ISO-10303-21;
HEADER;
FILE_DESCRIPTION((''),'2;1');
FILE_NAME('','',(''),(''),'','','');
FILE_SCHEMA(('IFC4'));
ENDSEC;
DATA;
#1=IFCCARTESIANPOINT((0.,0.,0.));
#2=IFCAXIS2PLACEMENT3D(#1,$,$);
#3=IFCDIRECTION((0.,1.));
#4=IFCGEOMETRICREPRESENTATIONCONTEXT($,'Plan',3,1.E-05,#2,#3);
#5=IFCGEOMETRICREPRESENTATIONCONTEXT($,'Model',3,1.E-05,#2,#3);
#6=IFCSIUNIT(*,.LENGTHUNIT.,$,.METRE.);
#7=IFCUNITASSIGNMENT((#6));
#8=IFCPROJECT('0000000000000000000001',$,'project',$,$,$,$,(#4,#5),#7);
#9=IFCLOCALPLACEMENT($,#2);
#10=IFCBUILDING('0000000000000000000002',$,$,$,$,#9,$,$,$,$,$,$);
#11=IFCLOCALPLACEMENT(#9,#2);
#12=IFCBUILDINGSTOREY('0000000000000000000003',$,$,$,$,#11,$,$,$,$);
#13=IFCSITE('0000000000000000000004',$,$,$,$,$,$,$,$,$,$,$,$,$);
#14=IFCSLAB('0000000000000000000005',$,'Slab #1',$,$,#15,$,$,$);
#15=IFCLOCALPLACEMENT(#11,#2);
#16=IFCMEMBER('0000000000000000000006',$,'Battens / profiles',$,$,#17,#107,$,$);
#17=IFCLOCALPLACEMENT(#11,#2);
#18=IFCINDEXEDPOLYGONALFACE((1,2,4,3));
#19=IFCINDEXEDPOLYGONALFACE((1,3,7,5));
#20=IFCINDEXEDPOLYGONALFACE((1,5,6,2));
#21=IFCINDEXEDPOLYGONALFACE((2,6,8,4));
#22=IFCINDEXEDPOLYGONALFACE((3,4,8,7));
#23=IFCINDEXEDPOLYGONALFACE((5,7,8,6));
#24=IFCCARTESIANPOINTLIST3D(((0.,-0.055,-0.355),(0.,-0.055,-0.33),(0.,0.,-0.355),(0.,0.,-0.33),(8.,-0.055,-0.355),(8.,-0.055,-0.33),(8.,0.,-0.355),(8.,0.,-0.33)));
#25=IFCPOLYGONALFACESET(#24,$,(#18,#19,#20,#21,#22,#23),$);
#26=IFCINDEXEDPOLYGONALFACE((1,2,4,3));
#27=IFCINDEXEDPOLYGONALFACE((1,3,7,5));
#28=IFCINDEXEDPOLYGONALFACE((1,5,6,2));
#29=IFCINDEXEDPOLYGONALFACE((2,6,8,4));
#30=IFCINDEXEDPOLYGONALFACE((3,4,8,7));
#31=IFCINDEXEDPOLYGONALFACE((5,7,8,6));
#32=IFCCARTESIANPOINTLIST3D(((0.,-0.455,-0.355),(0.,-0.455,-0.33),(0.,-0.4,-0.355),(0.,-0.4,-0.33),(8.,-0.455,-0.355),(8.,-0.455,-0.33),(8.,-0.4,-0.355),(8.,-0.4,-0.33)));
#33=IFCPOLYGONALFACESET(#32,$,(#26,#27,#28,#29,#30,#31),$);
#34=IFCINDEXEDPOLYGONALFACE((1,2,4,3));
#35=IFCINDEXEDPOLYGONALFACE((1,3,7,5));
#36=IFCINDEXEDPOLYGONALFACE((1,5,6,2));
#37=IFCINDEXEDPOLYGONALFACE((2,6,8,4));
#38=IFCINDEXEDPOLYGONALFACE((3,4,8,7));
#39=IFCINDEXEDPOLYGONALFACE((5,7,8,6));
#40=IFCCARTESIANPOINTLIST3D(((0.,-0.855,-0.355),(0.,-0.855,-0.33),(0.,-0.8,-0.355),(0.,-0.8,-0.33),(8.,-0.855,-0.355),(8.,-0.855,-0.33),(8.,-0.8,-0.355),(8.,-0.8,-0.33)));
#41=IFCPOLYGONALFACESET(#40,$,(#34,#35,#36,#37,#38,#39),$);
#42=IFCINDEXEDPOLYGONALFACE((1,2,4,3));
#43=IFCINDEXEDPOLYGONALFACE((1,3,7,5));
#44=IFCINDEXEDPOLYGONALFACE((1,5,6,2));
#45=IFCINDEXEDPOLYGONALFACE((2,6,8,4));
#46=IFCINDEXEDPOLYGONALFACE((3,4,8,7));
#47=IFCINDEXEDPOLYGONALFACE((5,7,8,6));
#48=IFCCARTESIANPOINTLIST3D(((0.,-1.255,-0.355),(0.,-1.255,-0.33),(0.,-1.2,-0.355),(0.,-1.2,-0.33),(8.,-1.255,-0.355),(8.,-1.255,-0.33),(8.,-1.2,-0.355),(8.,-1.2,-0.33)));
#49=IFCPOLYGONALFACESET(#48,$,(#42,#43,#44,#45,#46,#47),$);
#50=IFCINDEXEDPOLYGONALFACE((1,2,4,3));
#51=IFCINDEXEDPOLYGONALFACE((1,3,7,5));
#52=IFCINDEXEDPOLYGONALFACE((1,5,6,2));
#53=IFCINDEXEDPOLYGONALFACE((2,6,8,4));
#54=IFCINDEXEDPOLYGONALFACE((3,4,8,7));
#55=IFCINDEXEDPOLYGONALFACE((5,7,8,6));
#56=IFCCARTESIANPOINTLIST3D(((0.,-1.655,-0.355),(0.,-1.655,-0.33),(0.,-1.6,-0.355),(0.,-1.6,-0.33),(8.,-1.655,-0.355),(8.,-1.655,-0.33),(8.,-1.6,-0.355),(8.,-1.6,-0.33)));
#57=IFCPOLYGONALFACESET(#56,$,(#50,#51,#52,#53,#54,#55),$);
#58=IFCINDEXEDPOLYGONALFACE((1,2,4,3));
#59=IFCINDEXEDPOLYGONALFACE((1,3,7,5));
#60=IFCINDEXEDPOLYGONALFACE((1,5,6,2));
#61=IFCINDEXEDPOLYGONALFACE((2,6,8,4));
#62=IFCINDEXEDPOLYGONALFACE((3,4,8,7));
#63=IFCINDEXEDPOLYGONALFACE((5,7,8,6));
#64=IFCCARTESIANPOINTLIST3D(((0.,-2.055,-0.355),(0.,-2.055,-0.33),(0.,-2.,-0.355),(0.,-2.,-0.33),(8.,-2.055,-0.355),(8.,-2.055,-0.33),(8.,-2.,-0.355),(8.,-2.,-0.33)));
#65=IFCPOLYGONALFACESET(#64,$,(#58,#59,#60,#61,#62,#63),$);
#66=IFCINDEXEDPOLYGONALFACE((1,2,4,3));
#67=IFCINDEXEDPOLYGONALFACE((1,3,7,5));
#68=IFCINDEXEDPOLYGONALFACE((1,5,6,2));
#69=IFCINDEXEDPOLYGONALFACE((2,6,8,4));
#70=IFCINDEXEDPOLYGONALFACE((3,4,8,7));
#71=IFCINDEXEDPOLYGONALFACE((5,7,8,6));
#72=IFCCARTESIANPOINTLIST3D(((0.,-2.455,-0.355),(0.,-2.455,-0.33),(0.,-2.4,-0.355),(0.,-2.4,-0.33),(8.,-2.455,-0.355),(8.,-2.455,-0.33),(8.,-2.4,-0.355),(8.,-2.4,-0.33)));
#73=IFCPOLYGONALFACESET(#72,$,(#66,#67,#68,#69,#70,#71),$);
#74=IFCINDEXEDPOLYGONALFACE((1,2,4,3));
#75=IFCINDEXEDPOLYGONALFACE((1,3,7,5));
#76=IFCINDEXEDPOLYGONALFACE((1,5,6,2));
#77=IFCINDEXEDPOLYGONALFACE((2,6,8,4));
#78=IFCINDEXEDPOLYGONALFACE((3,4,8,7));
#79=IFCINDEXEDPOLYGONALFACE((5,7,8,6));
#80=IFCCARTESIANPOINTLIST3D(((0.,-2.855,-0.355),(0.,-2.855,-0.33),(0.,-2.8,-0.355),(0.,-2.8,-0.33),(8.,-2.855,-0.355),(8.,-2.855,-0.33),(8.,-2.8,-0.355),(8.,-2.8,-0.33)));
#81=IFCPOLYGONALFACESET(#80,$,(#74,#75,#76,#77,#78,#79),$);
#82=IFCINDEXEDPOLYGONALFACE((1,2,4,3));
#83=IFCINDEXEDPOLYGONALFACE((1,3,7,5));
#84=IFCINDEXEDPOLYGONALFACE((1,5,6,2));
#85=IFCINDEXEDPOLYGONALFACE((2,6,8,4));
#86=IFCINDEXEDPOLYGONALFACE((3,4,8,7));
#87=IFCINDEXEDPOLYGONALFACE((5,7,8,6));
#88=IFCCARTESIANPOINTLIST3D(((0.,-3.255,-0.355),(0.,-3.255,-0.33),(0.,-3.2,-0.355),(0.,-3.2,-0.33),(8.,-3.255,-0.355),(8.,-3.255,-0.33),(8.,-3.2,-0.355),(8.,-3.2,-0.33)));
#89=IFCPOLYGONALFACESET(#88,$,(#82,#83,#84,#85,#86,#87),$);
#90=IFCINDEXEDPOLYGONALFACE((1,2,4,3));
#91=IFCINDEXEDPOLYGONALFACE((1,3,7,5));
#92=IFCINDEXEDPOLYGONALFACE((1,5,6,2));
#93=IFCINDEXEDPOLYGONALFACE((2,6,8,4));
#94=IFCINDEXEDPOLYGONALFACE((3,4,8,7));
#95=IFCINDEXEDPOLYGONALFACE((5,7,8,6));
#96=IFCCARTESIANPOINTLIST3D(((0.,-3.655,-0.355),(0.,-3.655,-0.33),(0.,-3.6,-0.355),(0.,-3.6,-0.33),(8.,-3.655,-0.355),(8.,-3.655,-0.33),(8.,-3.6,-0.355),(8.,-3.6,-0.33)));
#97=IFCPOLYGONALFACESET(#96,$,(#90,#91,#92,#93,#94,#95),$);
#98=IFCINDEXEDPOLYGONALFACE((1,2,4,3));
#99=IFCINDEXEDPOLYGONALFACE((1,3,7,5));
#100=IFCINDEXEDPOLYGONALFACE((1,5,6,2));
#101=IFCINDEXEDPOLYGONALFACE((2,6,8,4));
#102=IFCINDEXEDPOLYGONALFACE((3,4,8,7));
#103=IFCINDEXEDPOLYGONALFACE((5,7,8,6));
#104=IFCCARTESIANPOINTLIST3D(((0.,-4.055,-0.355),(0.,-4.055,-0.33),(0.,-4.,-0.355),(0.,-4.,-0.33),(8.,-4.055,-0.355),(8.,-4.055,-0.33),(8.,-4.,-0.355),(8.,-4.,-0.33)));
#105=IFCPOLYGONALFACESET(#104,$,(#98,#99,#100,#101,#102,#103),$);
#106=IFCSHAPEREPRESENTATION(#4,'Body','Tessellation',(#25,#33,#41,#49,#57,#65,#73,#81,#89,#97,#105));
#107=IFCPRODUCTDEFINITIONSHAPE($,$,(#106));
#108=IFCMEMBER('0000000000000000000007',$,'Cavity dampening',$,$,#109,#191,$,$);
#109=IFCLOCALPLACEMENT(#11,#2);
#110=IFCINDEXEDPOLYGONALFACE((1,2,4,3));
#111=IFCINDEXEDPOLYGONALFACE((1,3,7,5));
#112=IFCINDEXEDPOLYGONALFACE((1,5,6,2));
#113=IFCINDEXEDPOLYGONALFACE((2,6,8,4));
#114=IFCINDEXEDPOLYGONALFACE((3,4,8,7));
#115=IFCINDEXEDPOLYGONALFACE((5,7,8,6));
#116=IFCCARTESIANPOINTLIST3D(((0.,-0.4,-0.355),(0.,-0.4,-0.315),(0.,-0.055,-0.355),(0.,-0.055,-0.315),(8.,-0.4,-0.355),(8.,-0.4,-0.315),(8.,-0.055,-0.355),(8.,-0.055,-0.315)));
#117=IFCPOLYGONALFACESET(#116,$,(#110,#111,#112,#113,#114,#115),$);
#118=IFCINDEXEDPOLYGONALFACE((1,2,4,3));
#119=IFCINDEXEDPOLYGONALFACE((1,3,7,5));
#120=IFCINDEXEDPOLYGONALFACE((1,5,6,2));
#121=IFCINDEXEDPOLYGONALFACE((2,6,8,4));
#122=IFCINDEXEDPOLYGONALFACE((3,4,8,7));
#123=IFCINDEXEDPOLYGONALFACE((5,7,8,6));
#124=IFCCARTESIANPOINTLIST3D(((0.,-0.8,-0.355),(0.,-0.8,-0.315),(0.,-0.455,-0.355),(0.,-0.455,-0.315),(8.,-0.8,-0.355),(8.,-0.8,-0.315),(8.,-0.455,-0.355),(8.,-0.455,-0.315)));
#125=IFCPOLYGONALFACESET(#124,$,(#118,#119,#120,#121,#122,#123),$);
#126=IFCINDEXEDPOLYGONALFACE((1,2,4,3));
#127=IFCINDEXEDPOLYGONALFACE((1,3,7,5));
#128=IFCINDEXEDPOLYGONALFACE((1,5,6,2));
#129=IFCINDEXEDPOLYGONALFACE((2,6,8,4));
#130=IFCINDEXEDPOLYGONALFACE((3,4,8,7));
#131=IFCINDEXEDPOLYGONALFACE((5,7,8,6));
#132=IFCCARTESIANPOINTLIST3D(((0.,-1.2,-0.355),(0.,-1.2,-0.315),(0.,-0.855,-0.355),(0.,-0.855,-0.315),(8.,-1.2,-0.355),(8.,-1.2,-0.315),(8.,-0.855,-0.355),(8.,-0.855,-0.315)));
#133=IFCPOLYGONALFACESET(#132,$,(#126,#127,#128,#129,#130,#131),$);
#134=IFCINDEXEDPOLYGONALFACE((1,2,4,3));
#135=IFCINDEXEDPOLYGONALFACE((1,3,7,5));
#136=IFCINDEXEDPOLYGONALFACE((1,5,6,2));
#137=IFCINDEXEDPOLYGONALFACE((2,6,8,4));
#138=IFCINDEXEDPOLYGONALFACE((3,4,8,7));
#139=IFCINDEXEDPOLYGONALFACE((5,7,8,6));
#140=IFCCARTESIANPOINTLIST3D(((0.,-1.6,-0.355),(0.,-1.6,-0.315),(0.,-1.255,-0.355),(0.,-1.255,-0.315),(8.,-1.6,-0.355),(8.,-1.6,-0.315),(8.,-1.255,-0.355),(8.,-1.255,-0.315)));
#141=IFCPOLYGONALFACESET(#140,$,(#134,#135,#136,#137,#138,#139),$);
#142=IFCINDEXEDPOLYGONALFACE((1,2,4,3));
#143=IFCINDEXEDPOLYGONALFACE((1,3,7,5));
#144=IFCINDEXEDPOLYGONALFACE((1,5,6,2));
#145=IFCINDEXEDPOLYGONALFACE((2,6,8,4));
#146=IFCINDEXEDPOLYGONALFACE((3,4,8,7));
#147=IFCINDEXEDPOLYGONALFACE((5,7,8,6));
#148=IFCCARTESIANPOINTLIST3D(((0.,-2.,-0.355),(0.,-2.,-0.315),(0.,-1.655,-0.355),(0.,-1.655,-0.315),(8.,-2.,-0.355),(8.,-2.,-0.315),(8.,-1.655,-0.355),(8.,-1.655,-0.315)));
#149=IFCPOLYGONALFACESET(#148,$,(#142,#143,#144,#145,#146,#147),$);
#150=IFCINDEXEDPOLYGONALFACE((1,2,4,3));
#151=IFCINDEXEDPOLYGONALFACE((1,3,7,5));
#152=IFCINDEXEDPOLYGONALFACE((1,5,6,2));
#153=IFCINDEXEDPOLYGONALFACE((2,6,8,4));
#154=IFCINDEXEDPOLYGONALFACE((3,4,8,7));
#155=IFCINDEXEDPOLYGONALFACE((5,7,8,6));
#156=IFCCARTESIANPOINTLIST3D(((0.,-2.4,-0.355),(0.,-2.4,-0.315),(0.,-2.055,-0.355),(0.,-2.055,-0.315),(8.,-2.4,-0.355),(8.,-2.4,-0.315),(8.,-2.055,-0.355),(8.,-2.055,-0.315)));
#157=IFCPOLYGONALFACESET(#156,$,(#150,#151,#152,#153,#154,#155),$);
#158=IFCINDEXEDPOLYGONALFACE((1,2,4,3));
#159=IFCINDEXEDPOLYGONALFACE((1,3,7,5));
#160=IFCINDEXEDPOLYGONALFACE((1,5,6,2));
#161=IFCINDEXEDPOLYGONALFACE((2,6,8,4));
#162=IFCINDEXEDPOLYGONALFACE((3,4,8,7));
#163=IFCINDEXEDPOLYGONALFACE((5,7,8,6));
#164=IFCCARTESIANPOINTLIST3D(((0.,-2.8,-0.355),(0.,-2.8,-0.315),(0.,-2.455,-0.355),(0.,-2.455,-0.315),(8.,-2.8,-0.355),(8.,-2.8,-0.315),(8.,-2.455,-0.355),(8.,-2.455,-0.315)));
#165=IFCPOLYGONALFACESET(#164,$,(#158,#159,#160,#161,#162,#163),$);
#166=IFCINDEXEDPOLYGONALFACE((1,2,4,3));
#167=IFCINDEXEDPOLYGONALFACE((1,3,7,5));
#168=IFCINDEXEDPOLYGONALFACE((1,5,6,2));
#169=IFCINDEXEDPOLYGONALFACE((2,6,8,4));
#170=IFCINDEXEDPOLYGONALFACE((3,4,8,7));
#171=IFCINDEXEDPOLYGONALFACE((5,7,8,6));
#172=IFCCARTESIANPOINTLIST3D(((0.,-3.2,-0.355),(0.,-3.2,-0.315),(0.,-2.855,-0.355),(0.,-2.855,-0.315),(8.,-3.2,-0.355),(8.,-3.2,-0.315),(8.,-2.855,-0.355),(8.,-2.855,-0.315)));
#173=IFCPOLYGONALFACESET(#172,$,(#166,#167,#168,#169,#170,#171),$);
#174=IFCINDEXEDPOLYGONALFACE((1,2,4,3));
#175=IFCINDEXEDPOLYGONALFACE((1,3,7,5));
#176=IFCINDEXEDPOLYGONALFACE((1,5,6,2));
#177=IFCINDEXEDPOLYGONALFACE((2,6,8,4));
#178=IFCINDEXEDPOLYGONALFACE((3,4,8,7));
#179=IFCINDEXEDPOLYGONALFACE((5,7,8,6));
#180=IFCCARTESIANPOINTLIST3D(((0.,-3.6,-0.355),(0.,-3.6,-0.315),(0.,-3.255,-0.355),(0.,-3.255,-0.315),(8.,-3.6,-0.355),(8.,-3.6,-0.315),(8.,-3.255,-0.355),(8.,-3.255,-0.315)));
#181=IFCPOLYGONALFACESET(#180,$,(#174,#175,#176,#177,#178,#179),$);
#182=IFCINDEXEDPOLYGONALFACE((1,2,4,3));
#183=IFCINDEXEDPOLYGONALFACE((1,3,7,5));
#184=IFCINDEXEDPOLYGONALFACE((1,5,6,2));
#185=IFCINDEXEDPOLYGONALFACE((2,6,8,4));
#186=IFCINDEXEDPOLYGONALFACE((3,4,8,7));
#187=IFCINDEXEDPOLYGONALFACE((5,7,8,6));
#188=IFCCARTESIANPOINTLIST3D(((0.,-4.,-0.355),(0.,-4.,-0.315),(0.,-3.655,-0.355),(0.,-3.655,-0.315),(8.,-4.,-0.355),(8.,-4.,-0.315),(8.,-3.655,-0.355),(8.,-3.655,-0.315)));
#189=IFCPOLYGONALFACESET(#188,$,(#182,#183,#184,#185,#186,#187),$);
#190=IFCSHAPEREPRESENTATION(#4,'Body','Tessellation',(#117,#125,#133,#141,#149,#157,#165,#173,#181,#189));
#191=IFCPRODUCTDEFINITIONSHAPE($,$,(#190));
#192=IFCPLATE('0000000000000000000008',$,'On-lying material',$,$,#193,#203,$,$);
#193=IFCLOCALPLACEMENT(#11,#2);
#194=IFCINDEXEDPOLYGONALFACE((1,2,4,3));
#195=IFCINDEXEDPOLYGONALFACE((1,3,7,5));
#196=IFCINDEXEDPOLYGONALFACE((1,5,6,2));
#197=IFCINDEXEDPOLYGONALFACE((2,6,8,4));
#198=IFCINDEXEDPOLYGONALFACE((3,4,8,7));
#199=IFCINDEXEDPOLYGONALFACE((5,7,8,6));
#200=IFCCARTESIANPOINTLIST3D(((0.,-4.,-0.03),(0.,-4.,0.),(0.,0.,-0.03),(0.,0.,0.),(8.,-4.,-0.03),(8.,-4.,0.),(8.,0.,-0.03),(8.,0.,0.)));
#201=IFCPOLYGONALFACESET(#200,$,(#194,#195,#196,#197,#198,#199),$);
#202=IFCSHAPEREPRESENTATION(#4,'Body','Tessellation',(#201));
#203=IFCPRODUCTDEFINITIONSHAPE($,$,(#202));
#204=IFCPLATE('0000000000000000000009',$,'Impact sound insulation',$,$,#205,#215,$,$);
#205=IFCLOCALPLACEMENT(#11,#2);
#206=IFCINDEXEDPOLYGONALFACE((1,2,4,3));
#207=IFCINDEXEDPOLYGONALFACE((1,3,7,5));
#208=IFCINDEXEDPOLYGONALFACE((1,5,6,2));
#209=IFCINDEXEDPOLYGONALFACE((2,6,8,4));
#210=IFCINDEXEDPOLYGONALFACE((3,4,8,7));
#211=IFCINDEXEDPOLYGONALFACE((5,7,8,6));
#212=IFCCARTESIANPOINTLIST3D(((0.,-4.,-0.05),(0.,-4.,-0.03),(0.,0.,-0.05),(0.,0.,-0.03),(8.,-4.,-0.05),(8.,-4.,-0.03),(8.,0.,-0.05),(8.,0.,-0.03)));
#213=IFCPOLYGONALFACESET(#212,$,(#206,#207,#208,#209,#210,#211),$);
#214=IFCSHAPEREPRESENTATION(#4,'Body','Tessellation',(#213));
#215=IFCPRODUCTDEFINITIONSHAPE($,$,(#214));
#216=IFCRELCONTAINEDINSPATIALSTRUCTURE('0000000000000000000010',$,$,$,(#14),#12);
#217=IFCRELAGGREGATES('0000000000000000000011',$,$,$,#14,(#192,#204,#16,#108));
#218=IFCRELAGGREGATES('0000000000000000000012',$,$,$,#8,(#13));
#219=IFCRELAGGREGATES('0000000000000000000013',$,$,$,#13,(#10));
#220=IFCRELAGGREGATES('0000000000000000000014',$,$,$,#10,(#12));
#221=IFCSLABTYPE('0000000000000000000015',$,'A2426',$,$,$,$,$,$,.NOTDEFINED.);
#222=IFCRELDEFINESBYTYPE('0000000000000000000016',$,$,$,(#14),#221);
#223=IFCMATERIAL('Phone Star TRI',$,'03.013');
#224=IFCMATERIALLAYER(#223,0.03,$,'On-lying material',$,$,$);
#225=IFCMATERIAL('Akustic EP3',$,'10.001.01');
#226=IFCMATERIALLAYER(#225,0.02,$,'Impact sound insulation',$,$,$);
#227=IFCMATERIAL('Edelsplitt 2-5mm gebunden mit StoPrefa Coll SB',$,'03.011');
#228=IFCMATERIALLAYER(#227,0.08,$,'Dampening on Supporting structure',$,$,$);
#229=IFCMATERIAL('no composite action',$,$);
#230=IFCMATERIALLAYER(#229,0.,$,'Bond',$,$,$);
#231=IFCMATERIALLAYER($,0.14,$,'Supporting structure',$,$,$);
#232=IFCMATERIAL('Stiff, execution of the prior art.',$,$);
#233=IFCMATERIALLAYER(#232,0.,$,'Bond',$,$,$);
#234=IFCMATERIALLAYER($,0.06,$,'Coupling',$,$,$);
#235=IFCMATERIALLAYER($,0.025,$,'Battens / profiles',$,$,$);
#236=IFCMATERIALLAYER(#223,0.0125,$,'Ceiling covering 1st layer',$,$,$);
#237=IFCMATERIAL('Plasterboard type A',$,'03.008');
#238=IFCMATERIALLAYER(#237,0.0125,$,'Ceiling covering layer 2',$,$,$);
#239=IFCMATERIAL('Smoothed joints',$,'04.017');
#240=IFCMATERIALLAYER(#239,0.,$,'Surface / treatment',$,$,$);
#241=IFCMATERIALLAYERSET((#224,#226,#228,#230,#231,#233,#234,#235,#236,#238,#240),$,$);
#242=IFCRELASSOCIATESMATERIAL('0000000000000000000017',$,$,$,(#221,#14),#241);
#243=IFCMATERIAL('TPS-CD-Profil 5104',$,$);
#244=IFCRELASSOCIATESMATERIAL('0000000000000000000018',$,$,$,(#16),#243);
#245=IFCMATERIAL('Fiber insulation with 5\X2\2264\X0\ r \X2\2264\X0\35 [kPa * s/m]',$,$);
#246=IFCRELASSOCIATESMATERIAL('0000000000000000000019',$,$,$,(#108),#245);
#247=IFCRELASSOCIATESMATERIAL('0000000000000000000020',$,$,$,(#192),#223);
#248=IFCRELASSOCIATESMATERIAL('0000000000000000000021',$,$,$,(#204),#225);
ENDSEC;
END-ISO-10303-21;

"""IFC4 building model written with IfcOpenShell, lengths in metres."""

from ifc_helpers import new_model, si_unit, direction, frame, frame_2d, origin, origin_with_axes, place, context, project, spatial, rectangle, extrude, material, layer, layer_set, type_object, element, aggregate, save


model = new_model("IFC4")

# Units and contexts
plan_context = context("Plan", 3, precision=1e-05, world=origin(), true_north=direction((0.0, 1.0)))
model_context = context("Model", 3, precision=1e-05, world=origin(), true_north=direction((0.0, 1.0)))
ifc_project = project(units=[si_unit("LENGTHUNIT", "METRE")], contexts=[plan_context, model_context])

# Site, building, storey
site = spatial("IfcSite", under=ifc_project)
building_placement = place(None, origin())
building = spatial("IfcBuilding", under=site, at=building_placement)
storey_placement = place(building_placement, origin())
storey = spatial("IfcBuildingStorey", under=building, at=storey_placement)

# Slab, members, plates
ifc_material_1 = material(Name="Phone Star TRI", Category="03.013")
ifc_layer_1 = layer(ifc_material_1, 0.03, Name="On-lying material")
ifc_material_2 = material(Name="Akustic EP3", Category="10.001.01")
ifc_layer_2 = layer(ifc_material_2, 0.02, Name="Impact sound insulation")
ifc_material_3 = material(Name="Edelsplitt 2-5mm gebunden mit StoPrefa Coll SB", Category="03.011")
ifc_layer_3 = layer(ifc_material_3, 0.08, Name="Dampening on Supporting structure")
ifc_material_4 = material(Name="no composite action")
ifc_layer_4 = layer(ifc_material_4, 0.0, Name="Bond")
ifc_layer_5 = layer(None, 0.14, Name="Supporting structure")
ifc_material_5 = material(Name="Stiff, execution of the prior art.")
ifc_layer_6 = layer(ifc_material_5, 0.0, Name="Bond")
ifc_layer_7 = layer(None, 0.06, Name="Coupling")
ifc_layer_8 = layer(None, 0.025, Name="Battens / profiles")
ifc_layer_9 = layer(ifc_material_1, 0.0125, Name="Ceiling covering 1st layer")
ifc_material_6 = material(Name="Plasterboard type A", Category="03.008")
ifc_layer_10 = layer(ifc_material_6, 0.0125, Name="Ceiling covering layer 2")
ifc_material_7 = material(Name="Smoothed joints", Category="04.017")
ifc_layer_11 = layer(ifc_material_7, 0.0, Name="Surface / treatment")
ifc_layer_set = layer_set([ifc_layer_1, ifc_layer_2, ifc_layer_3, ifc_layer_4, ifc_layer_5, ifc_layer_6, ifc_layer_7, ifc_layer_8, ifc_layer_9, ifc_layer_10, ifc_layer_11])
slab_type = type_object("IfcSlabType", Name="A2426", PredefinedType="NOTDEFINED", material=ifc_layer_set)
slab_placement = place(None, frame((0.0, 0.0, 0.0), z_axis=(0.0, 0.0, -1.0), x_axis=(1.0, 0.0, 0.0)))
slab = element("IfcSlab", 1, at=slab_placement, inside=storey, type_object=slab_type, material=ifc_layer_set, Name="Slab #1")
ifc_material_8 = material(Name="TPS-CD-Profil 5104")
member_1_placement = place(slab_placement, origin())
member_1 = element("IfcMember", 2, at=member_1_placement, material=ifc_material_8, Name="Battens / profiles", context=plan_context, shape_type="SweptSolid", body=[
    extrude(rectangle(XDim=0.055, YDim=0.025, at=frame_2d((0.0275, 0.0125), x_axis=(1.0, 0.0))), frame((0.0, 0.0, 0.33), z_axis=(1.0, 0.0, 0.0), x_axis=(0.0, 1.0, 0.0)), (0.0, 0.0, 1.0), 8.0),
    extrude(rectangle(XDim=0.055, YDim=0.025, at=frame_2d((0.0275, 0.0125), x_axis=(1.0, 0.0))), frame((0.0, 0.4, 0.33), z_axis=(1.0, 0.0, 0.0), x_axis=(0.0, 1.0, 0.0)), (0.0, 0.0, 1.0), 8.0),
    extrude(rectangle(XDim=0.055, YDim=0.025, at=frame_2d((0.0275, 0.0125), x_axis=(1.0, 0.0))), frame((0.0, 0.8, 0.33), z_axis=(1.0, 0.0, 0.0), x_axis=(0.0, 1.0, 0.0)), (0.0, 0.0, 1.0), 8.0),
    extrude(rectangle(XDim=0.055, YDim=0.025, at=frame_2d((0.0275, 0.0125), x_axis=(1.0, 0.0))), frame((0.0, 1.2, 0.33), z_axis=(1.0, 0.0, 0.0), x_axis=(0.0, 1.0, 0.0)), (0.0, 0.0, 1.0), 8.0),
    extrude(rectangle(XDim=0.055, YDim=0.025, at=frame_2d((0.0275, 0.0125), x_axis=(1.0, 0.0))), frame((0.0, 1.6, 0.33), z_axis=(1.0, 0.0, 0.0), x_axis=(0.0, 1.0, 0.0)), (0.0, 0.0, 1.0), 8.0),
    extrude(rectangle(XDim=0.055, YDim=0.025, at=frame_2d((0.0275, 0.0125), x_axis=(1.0, 0.0))), frame((0.0, 2.0, 0.33), z_axis=(1.0, 0.0, 0.0), x_axis=(0.0, 1.0, 0.0)), (0.0, 0.0, 1.0), 8.0),
    extrude(rectangle(XDim=0.055, YDim=0.025, at=frame_2d((0.0275, 0.0125), x_axis=(1.0, 0.0))), frame((0.0, 2.4, 0.33), z_axis=(1.0, 0.0, 0.0), x_axis=(0.0, 1.0, 0.0)), (0.0, 0.0, 1.0), 8.0),
    extrude(rectangle(XDim=0.055, YDim=0.025, at=frame_2d((0.0275, 0.0125), x_axis=(1.0, 0.0))), frame((0.0, 2.8, 0.33), z_axis=(1.0, 0.0, 0.0), x_axis=(0.0, 1.0, 0.0)), (0.0, 0.0, 1.0), 8.0),
    extrude(rectangle(XDim=0.055, YDim=0.025, at=frame_2d((0.0275, 0.0125), x_axis=(1.0, 0.0))), frame((0.0, 3.2, 0.33), z_axis=(1.0, 0.0, 0.0), x_axis=(0.0, 1.0, 0.0)), (0.0, 0.0, 1.0), 8.0),
    extrude(rectangle(XDim=0.055, YDim=0.025, at=frame_2d((0.0275, 0.0125), x_axis=(1.0, 0.0))), frame((0.0, 3.6, 0.33), z_axis=(1.0, 0.0, 0.0), x_axis=(0.0, 1.0, 0.0)), (0.0, 0.0, 1.0), 8.0),
    extrude(rectangle(XDim=0.055, YDim=0.025, at=frame_2d((0.0275, 0.0125), x_axis=(1.0, 0.0))), frame((0.0, 4.0, 0.33), z_axis=(1.0, 0.0, 0.0), x_axis=(0.0, 1.0, 0.0)), (0.0, 0.0, 1.0), 8.0),
])
ifc_material_9 = material(Name="Fiber insulation with 5≤ r ≤35 [kPa * s/m]")
member_2_placement = place(slab_placement, origin())
member_2 = element("IfcMember", 3, at=member_2_placement, material=ifc_material_9, Name="Cavity dampening", context=plan_context, shape_type="SweptSolid", body=[
    extrude(rectangle(XDim=0.345, YDim=0.04, at=frame_2d((0.1725, 0.02), x_axis=(1.0, 0.0))), frame((0.0, 0.055, 0.315), z_axis=(1.0, 0.0, 0.0), x_axis=(0.0, 1.0, 0.0)), (0.0, 0.0, 1.0), 8.0),
    extrude(rectangle(XDim=0.345, YDim=0.04, at=frame_2d((0.1725, 0.02), x_axis=(1.0, 0.0))), frame((0.0, 0.455, 0.315), z_axis=(1.0, 0.0, 0.0), x_axis=(0.0, 1.0, 0.0)), (0.0, 0.0, 1.0), 8.0),
    extrude(rectangle(XDim=0.345, YDim=0.04, at=frame_2d((0.1725, 0.02), x_axis=(1.0, 0.0))), frame((0.0, 0.855, 0.315), z_axis=(1.0, 0.0, 0.0), x_axis=(0.0, 1.0, 0.0)), (0.0, 0.0, 1.0), 8.0),
    extrude(rectangle(XDim=0.345, YDim=0.04, at=frame_2d((0.1725, 0.02), x_axis=(1.0, 0.0))), frame((0.0, 1.255, 0.315), z_axis=(1.0, 0.0, 0.0), x_axis=(0.0, 1.0, 0.0)), (0.0, 0.0, 1.0), 8.0),
    extrude(rectangle(XDim=0.345, YDim=0.04, at=frame_2d((0.1725, 0.02), x_axis=(1.0, 0.0))), frame((0.0, 1.655, 0.315), z_axis=(1.0, 0.0, 0.0), x_axis=(0.0, 1.0, 0.0)), (0.0, 0.0, 1.0), 8.0),
    extrude(rectangle(XDim=0.345, YDim=0.04, at=frame_2d((0.1725, 0.02), x_axis=(1.0, 0.0))), frame((0.0, 2.055, 0.315), z_axis=(1.0, 0.0, 0.0), x_axis=(0.0, 1.0, 0.0)), (0.0, 0.0, 1.0), 8.0),
    extrude(rectangle(XDim=0.345, YDim=0.04, at=frame_2d((0.1725, 0.02), x_axis=(1.0, 0.0))), frame((0.0, 2.455, 0.315), z_axis=(1.0, 0.0, 0.0), x_axis=(0.0, 1.0, 0.0)), (0.0, 0.0, 1.0), 8.0),
    extrude(rectangle(XDim=0.345, YDim=0.04, at=frame_2d((0.1725, 0.02), x_axis=(1.0, 0.0))), frame((0.0, 2.855, 0.315), z_axis=(1.0, 0.0, 0.0), x_axis=(0.0, 1.0, 0.0)), (0.0, 0.0, 1.0), 8.0),
    extrude(rectangle(XDim=0.345, YDim=0.04, at=frame_2d((0.1725, 0.02), x_axis=(1.0, 0.0))), frame((0.0, 3.255, 0.315), z_axis=(1.0, 0.0, 0.0), x_axis=(0.0, 1.0, 0.0)), (0.0, 0.0, 1.0), 8.0),
    extrude(rectangle(XDim=0.345, YDim=0.04, at=frame_2d((0.1725, 0.02), x_axis=(1.0, 0.0))), frame((0.0, 3.655, 0.315), z_axis=(1.0, 0.0, 0.0), x_axis=(0.0, 1.0, 0.0)), (0.0, 0.0, 1.0), 8.0),
])
plate_1_placement = place(slab_placement, origin())
plate_1 = element("IfcPlate", 4, at=plate_1_placement, material=ifc_material_1, Name="On-lying material", context=plan_context, shape_type="SweptSolid", body=[
    extrude(rectangle(XDim=8.0, YDim=4.0, at=frame_2d((4.0, 2.0), x_axis=(1.0, 0.0))), origin_with_axes(), (0.0, 0.0, 1.0), 0.03),
])
plate_2_placement = place(slab_placement, origin())
plate_2 = element("IfcPlate", 5, at=plate_2_placement, material=ifc_material_2, Name="Impact sound insulation", context=plan_context, shape_type="SweptSolid", body=[
    extrude(rectangle(XDim=8.0, YDim=4.0, at=frame_2d((4.0, 2.0), x_axis=(1.0, 0.0))), frame((0.0, 0.0, 0.03), z_axis=(0.0, 0.0, 1.0), x_axis=(1.0, 0.0, 0.0)), (0.0, 0.0, 1.0), 0.02),
])
aggregate(slab, [plate_1, plate_2, member_1, member_2])

save(model, "model.ifc")
